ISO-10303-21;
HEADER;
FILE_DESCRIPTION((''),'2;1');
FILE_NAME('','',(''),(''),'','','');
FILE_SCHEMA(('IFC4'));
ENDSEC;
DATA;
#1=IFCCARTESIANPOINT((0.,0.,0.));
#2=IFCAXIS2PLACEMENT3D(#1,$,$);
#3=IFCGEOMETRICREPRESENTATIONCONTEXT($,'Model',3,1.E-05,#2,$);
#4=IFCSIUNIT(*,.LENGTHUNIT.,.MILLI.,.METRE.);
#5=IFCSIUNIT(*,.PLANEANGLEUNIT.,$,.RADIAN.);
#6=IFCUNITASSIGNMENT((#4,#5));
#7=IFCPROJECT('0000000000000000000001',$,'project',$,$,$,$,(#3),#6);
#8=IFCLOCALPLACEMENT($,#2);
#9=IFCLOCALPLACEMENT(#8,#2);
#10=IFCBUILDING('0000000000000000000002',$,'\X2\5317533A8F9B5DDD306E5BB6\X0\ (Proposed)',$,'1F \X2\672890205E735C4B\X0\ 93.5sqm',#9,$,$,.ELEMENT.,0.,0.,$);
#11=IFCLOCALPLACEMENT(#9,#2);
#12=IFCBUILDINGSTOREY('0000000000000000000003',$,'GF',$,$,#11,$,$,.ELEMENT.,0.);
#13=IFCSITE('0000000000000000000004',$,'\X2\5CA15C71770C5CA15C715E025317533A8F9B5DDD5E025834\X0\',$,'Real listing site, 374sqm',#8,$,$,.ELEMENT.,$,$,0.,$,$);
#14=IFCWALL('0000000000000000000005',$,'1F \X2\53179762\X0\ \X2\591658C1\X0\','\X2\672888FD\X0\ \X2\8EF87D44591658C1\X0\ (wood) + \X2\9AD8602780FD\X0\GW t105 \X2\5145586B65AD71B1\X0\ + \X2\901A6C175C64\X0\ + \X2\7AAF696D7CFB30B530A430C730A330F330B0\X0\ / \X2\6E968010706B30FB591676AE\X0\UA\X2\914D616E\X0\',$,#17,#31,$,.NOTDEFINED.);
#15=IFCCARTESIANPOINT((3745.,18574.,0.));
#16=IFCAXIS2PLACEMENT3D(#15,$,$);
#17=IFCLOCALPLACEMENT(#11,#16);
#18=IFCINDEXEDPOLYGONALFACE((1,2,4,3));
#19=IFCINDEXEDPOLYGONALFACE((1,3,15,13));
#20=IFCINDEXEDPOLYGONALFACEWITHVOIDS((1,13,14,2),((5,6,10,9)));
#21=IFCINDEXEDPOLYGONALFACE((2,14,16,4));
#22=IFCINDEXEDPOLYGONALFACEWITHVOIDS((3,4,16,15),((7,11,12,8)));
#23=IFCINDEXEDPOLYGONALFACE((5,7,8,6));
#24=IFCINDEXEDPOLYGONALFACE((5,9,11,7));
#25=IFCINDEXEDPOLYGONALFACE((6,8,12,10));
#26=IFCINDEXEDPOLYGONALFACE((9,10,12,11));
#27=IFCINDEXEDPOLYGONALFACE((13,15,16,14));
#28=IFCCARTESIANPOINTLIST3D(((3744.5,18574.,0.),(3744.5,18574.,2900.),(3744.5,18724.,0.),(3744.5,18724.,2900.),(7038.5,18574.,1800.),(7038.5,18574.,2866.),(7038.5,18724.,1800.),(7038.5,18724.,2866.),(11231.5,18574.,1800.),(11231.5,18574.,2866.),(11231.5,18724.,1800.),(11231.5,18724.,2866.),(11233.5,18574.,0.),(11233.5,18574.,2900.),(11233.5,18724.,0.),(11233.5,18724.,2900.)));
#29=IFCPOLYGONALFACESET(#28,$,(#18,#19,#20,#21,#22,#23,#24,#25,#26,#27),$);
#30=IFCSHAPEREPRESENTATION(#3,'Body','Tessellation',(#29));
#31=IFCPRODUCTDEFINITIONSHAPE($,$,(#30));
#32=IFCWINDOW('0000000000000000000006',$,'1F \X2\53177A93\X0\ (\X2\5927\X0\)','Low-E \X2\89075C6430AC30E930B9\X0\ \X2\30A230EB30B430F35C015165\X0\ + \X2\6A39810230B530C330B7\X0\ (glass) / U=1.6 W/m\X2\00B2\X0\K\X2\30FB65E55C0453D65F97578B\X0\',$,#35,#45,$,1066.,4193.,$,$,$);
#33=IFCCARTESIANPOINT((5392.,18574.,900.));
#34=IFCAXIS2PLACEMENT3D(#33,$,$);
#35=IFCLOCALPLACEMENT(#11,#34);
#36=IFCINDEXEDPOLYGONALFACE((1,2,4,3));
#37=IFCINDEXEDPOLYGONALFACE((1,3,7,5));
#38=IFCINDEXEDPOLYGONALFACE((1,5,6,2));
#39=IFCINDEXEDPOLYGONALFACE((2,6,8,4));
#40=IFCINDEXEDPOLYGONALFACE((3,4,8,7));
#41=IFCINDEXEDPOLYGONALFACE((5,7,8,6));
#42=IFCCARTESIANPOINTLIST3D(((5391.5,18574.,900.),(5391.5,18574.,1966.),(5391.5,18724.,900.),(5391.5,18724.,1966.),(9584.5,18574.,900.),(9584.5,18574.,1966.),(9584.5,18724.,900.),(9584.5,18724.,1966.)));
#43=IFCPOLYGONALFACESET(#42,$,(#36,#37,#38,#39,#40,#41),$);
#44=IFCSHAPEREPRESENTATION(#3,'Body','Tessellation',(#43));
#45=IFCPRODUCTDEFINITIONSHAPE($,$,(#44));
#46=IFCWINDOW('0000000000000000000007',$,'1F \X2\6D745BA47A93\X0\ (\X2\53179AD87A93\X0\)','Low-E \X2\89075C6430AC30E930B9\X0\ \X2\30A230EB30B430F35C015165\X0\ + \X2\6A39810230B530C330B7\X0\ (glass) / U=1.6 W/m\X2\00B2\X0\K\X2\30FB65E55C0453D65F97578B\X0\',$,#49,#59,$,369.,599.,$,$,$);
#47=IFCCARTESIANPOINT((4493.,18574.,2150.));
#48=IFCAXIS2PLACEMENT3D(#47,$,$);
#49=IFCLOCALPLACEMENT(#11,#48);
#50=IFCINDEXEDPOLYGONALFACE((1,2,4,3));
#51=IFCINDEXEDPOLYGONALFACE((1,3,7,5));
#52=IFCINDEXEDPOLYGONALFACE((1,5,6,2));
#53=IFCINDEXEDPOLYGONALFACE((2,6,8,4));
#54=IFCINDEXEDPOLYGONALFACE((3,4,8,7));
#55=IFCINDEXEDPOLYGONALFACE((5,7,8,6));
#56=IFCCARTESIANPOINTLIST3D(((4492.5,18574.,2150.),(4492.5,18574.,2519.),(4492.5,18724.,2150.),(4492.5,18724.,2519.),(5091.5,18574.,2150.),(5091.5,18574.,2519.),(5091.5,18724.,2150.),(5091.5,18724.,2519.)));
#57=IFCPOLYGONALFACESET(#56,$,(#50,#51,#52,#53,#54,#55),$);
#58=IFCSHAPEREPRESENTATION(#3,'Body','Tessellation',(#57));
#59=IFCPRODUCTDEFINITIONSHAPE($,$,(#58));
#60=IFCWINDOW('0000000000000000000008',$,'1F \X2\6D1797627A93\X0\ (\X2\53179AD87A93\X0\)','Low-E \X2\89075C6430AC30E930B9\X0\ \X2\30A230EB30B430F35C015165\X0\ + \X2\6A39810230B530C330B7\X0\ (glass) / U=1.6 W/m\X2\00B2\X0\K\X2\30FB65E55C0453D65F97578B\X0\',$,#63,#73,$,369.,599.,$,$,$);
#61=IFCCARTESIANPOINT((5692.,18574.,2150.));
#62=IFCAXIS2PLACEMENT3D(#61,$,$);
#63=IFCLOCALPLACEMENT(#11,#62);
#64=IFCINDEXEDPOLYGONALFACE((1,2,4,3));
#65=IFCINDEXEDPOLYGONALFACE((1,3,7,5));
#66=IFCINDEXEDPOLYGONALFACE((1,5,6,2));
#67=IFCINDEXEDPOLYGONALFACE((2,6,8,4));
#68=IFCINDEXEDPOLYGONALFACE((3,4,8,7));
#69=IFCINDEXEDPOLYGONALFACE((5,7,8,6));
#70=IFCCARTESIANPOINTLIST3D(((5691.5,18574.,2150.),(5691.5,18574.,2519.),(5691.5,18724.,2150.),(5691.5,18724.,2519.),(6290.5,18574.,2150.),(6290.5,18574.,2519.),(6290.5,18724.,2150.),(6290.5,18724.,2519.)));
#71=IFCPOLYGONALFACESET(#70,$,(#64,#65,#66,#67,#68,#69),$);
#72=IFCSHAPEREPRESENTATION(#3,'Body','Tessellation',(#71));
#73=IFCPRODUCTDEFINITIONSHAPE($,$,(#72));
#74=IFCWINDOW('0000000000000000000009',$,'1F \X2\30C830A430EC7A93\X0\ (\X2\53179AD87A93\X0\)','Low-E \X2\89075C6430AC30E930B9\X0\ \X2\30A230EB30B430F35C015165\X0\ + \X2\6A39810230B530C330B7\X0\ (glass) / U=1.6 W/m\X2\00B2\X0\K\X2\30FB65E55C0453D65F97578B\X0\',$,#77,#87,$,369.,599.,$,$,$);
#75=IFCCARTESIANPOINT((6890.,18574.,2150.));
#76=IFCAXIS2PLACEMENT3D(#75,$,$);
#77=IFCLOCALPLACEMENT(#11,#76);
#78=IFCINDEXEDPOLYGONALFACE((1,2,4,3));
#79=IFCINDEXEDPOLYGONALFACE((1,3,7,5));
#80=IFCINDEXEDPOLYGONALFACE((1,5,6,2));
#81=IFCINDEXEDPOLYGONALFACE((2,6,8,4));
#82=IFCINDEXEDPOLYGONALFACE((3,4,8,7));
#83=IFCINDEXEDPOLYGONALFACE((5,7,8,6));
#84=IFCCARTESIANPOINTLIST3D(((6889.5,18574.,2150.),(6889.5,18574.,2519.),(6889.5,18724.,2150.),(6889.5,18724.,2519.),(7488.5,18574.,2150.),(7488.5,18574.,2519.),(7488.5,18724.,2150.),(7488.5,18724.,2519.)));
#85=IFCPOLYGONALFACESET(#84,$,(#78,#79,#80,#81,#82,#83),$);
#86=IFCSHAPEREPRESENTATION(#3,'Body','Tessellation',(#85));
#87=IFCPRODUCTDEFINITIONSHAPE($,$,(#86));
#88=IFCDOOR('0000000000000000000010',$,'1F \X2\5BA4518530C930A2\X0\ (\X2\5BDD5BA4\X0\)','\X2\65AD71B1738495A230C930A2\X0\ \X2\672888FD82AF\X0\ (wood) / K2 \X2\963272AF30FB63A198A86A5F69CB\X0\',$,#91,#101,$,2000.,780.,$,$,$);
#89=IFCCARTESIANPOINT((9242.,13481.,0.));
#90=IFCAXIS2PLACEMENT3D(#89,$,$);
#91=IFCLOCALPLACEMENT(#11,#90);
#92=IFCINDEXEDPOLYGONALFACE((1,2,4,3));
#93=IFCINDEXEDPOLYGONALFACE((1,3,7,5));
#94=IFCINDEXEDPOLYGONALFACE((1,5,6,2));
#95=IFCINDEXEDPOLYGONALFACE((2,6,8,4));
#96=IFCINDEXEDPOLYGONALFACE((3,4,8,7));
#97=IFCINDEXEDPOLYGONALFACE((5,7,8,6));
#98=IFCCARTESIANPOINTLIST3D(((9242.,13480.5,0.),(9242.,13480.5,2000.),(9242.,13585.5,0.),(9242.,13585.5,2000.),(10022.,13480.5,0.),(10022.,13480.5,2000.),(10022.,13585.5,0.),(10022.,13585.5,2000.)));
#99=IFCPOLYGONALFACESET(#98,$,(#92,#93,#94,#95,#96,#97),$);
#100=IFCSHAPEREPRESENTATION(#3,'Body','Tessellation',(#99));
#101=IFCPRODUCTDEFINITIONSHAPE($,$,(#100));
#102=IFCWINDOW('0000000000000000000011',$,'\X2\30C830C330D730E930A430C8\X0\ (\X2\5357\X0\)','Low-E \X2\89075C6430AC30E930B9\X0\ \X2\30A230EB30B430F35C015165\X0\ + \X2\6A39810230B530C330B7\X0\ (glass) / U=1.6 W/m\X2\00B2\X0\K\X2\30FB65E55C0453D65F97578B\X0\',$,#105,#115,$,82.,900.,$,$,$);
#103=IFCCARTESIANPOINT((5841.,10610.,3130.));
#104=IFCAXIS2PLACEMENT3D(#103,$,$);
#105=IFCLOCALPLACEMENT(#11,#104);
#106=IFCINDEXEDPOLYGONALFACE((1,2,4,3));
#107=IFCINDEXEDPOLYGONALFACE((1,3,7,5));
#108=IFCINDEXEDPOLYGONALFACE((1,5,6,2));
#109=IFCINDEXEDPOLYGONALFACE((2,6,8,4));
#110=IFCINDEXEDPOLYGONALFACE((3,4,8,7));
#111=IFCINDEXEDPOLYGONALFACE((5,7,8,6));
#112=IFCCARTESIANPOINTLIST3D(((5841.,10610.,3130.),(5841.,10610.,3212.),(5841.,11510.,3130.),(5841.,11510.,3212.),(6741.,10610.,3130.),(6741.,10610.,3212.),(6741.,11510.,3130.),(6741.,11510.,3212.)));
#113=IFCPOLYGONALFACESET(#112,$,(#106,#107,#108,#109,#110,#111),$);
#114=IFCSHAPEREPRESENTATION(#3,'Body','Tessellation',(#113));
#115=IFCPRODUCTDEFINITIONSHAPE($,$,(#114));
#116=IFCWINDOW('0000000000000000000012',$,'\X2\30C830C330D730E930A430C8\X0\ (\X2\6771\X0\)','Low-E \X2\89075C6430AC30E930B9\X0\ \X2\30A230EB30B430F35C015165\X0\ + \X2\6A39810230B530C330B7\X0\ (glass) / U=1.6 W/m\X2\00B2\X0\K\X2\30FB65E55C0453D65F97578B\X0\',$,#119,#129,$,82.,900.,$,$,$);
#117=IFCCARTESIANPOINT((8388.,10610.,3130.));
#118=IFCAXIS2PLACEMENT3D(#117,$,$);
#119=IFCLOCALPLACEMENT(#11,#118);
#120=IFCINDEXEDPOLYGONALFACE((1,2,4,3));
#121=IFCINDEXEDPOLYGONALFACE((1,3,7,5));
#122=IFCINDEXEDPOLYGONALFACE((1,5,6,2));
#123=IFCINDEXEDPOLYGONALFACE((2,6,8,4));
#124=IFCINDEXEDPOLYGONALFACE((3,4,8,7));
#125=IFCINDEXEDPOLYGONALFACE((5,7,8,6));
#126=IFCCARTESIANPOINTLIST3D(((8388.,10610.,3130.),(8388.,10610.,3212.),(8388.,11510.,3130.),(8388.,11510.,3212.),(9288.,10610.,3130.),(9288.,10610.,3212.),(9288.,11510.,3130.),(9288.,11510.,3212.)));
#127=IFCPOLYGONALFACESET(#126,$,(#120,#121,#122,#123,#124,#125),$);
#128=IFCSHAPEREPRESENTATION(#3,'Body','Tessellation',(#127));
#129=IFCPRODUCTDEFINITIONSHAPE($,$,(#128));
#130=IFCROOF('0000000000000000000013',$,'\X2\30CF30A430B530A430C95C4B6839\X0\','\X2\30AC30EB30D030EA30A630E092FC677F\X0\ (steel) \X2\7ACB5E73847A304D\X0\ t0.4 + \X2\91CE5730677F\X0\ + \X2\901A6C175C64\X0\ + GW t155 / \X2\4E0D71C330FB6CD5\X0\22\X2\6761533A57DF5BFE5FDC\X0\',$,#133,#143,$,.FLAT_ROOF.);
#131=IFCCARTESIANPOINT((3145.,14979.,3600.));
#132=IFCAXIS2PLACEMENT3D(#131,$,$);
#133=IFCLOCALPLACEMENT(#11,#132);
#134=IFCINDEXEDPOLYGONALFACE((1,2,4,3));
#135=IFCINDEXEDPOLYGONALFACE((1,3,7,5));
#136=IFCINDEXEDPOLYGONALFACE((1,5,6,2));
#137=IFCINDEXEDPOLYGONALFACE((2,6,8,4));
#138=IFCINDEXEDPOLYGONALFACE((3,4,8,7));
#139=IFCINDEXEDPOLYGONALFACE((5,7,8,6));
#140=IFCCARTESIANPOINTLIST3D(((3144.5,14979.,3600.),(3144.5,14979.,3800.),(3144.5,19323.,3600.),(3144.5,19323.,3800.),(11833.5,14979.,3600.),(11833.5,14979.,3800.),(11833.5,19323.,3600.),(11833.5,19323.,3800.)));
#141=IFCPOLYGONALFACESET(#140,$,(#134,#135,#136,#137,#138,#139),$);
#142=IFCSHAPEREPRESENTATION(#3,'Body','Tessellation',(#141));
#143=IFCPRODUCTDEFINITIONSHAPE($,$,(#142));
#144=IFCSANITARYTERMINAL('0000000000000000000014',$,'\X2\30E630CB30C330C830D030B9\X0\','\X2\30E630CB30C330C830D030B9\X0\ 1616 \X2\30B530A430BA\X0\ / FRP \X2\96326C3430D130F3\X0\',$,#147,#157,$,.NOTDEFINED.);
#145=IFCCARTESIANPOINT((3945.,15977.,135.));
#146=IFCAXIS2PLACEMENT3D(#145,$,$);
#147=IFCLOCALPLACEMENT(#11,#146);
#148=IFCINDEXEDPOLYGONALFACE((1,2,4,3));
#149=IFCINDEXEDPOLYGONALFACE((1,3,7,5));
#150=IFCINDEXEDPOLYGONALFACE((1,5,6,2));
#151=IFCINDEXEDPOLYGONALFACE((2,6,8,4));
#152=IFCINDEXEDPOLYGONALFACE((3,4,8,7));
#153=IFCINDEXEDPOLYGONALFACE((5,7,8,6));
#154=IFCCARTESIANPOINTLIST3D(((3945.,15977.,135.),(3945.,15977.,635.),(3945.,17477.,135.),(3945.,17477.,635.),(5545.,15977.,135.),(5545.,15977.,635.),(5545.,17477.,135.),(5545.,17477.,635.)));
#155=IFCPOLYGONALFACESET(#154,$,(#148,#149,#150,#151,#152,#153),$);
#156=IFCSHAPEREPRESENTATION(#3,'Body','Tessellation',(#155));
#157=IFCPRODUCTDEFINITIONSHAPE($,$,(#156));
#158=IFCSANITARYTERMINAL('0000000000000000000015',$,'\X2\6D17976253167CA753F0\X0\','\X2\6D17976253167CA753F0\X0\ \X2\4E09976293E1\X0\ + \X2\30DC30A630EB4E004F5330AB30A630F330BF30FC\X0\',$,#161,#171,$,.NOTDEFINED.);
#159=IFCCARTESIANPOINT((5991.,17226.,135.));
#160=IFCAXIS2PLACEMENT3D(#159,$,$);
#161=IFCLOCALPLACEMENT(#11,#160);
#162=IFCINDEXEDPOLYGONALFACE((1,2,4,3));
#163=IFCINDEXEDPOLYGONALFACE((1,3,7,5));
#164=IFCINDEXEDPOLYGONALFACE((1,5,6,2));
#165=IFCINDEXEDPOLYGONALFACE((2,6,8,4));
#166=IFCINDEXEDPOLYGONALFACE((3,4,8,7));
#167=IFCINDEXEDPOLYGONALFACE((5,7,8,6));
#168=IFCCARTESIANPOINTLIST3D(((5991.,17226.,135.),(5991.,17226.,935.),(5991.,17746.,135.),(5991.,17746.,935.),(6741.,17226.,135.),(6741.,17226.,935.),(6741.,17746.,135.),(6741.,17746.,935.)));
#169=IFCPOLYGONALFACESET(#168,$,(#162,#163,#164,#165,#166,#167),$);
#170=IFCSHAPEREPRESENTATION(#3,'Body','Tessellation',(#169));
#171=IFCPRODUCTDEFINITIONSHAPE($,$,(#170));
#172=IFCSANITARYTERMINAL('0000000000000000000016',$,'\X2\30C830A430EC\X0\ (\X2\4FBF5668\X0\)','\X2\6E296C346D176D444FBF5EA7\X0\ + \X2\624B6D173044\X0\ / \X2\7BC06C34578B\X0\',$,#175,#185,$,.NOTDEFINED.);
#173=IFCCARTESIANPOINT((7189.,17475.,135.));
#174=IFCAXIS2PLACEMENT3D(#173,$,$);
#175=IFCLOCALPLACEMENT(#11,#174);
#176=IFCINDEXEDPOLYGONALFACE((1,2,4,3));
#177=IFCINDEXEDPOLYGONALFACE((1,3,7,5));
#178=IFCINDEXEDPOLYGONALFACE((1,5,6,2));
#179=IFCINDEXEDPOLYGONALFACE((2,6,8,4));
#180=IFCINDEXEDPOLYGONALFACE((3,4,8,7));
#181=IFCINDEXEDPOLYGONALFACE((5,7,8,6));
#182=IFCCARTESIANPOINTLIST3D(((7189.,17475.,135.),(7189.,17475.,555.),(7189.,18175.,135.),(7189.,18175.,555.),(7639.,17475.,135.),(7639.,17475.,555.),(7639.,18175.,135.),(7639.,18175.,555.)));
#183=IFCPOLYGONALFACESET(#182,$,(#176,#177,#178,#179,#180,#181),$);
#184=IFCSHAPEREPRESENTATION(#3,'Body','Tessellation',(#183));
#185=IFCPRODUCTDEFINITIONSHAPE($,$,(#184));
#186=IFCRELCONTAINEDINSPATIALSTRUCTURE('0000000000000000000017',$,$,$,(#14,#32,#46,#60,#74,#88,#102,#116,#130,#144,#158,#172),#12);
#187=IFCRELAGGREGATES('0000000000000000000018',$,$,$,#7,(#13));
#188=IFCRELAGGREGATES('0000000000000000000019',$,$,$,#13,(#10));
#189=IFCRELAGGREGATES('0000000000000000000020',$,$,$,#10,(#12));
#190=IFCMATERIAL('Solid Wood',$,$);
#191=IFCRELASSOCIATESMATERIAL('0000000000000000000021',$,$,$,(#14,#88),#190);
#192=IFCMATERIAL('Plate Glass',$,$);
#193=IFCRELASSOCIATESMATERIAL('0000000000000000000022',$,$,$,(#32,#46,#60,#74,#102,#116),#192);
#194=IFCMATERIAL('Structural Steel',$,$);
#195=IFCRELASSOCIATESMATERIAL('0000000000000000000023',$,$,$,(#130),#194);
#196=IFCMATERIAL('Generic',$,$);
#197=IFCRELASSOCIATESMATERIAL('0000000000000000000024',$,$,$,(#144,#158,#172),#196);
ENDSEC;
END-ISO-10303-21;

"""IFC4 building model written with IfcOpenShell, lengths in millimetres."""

from ifc_helpers import new_model, si_unit, frame, frame_2d, origin, place, context, project, spatial, rectangle, extrude, material, element, fill, save


model = new_model("IFC4")

# Units and contexts
model_context = context("Model", 3, precision=1e-05, world=origin())
ifc_project = project(units=[si_unit("LENGTHUNIT", "METRE", prefix="MILLI"), si_unit("PLANEANGLEUNIT", "RADIAN")], contexts=[model_context])

# Site, building, storey
site_placement = place(None, origin())
site = spatial("IfcSite", under=ifc_project, at=site_placement, Name="岡山県岡山市北区辛川市場", ObjectType="Real listing site, 374sqm", CompositionType="ELEMENT", RefElevation=0.0)
building_placement = place(site_placement, origin())
building = spatial("IfcBuilding", under=site, at=building_placement, Name="北区辛川の家 (Proposed)", ObjectType="1F 木造平屋 93.5sqm", CompositionType="ELEMENT", ElevationOfRefHeight=0.0, ElevationOfTerrain=0.0)
storey_placement = place(building_placement, origin())
storey = spatial("IfcBuildingStorey", under=building, at=storey_placement, Name="GF", CompositionType="ELEMENT", Elevation=0.0)

# Shared definitions
ifc_material_1 = material(Name="Solid Wood")

# Wall, openings, windows
wall_1_placement = place(storey_placement, frame((3745.0, 18574.0, 0.0)))
wall_1 = element("IfcWall", 1, at=wall_1_placement, inside=storey, material=ifc_material_1, Name="1F 北面 外壁", Description="木製 軸組外壁 (wood) + 高性能GW t105 充填断熱 + 通気層 + 窯業系サイディング / 準耐火・外皮UA配慮", PredefinedType="NOTDEFINED", context=model_context, shape_type="SweptSolid", body=[
    extrude(rectangle(XDim=7489.0, YDim=150.0, at=frame_2d((3744.0, 75.0))), frame((3745.0, 18574.0, 0.0)), (0.0, 0.0, 1.0), 2900.0),
])
opening_1_placement = place(storey_placement, frame((5392.0, 18574.0, 900.0)))
opening_1 = element("IfcOpeningElement", 2, at=opening_1_placement, cuts=wall_1, PredefinedType="NOTDEFINED", context=model_context, shape_type="SweptSolid", body=[
    extrude(rectangle(XDim=4193.0, YDim=150.0, at=frame_2d((2096.0, 75.0))), frame((5392.0, 18574.0, 900.0)), (0.0, 0.0, 1.0), 1066.0),
])
opening_2_placement = place(storey_placement, frame((4493.0, 18574.0, 2150.0)))
opening_2 = element("IfcOpeningElement", 3, at=opening_2_placement, cuts=wall_1, PredefinedType="NOTDEFINED", context=model_context, shape_type="SweptSolid", body=[
    extrude(rectangle(XDim=599.0, YDim=150.0, at=frame_2d((299.0, 75.0))), frame((4493.0, 18574.0, 2150.0)), (0.0, 0.0, 1.0), 369.0),
])
opening_3_placement = place(storey_placement, frame((5692.0, 18574.0, 2150.0)))
opening_3 = element("IfcOpeningElement", 4, at=opening_3_placement, cuts=wall_1, PredefinedType="NOTDEFINED", context=model_context, shape_type="SweptSolid", body=[
    extrude(rectangle(XDim=599.0, YDim=150.0, at=frame_2d((299.0, 75.0))), frame((5692.0, 18574.0, 2150.0)), (0.0, 0.0, 1.0), 369.0),
])
opening_4_placement = place(storey_placement, frame((6890.0, 18574.0, 2150.0)))
opening_4 = element("IfcOpeningElement", 5, at=opening_4_placement, cuts=wall_1, PredefinedType="NOTDEFINED", context=model_context, shape_type="SweptSolid", body=[
    extrude(rectangle(XDim=599.0, YDim=150.0, at=frame_2d((299.0, 75.0))), frame((6890.0, 18574.0, 2150.0)), (0.0, 0.0, 1.0), 369.0),
])
ifc_material_2 = material(Name="Plate Glass")
window_1_placement = place(storey_placement, frame((5392.0, 18574.0, 900.0)))
window_1 = element("IfcWindow", 6, at=window_1_placement, inside=storey, material=ifc_material_2, Name="1F 北窓 (大)", Description="Low-E 複層ガラス アルゴン封入 + 樹脂サッシ (glass) / U=1.6 W/m²K・日射取得型", OverallHeight=1066.0, OverallWidth=4193.0, context=model_context, shape_type="SweptSolid", body=[
    extrude(rectangle(XDim=4193.0, YDim=150.0, at=frame_2d((2096.0, 75.0))), frame((5392.0, 18574.0, 900.0)), (0.0, 0.0, 1.0), 1066.0),
])
fill(opening_1, window_1)
window_2_placement = place(storey_placement, frame((4493.0, 18574.0, 2150.0)))
window_2 = element("IfcWindow", 7, at=window_2_placement, inside=storey, material=ifc_material_2, Name="1F 浴室窓 (北高窓)", Description="Low-E 複層ガラス アルゴン封入 + 樹脂サッシ (glass) / U=1.6 W/m²K・日射取得型", OverallHeight=369.0, OverallWidth=599.0, context=model_context, shape_type="SweptSolid", body=[
    extrude(rectangle(XDim=599.0, YDim=150.0, at=frame_2d((299.0, 75.0))), frame((4493.0, 18574.0, 2150.0)), (0.0, 0.0, 1.0), 369.0),
])
fill(opening_2, window_2)
window_3_placement = place(storey_placement, frame((5692.0, 18574.0, 2150.0)))
window_3 = element("IfcWindow", 8, at=window_3_placement, inside=storey, material=ifc_material_2, Name="1F 洗面窓 (北高窓)", Description="Low-E 複層ガラス アルゴン封入 + 樹脂サッシ (glass) / U=1.6 W/m²K・日射取得型", OverallHeight=369.0, OverallWidth=599.0, context=model_context, shape_type="SweptSolid", body=[
    extrude(rectangle(XDim=599.0, YDim=150.0, at=frame_2d((299.0, 75.0))), frame((5692.0, 18574.0, 2150.0)), (0.0, 0.0, 1.0), 369.0),
])
fill(opening_3, window_3)
window_4_placement = place(storey_placement, frame((6890.0, 18574.0, 2150.0)))
window_4 = element("IfcWindow", 9, at=window_4_placement, inside=storey, material=ifc_material_2, Name="1F トイレ窓 (北高窓)", Description="Low-E 複層ガラス アルゴン封入 + 樹脂サッシ (glass) / U=1.6 W/m²K・日射取得型", OverallHeight=369.0, OverallWidth=599.0, context=model_context, shape_type="SweptSolid", body=[
    extrude(rectangle(XDim=599.0, YDim=150.0, at=frame_2d((299.0, 75.0))), frame((6890.0, 18574.0, 2150.0)), (0.0, 0.0, 1.0), 369.0),
])
fill(opening_4, window_4)

# Door
door_1_placement = place(storey_placement, frame((9242.0, 13481.0, 0.0)))
element("IfcDoor", 10, at=door_1_placement, inside=storey, material=ifc_material_1, Name="1F 室内ドア (寝室)", Description="断熱玄関ドア 木製芯 (wood) / K2 防犯・採風機構", OverallHeight=2000.0, OverallWidth=780.0, context=model_context, shape_type="SweptSolid", body=[
    extrude(rectangle(XDim=780.0, YDim=105.0, at=frame_2d((390.0, 52.0))), frame((9242.0, 13481.0, 0.0)), (0.0, 0.0, 1.0), 2000.0),
])

# Windows
window_5_placement = place(storey_placement, frame((5841.0, 10610.0, 3130.0)))
element("IfcWindow", 11, at=window_5_placement, inside=storey, material=ifc_material_2, Name="トップライト (南)", Description="Low-E 複層ガラス アルゴン封入 + 樹脂サッシ (glass) / U=1.6 W/m²K・日射取得型", OverallHeight=82.0, OverallWidth=900.0, context=model_context, shape_type="SweptSolid", body=[
    extrude(rectangle(XDim=900.0, YDim=900.0, at=frame_2d((450.0, 450.0))), frame((5841.0, 10610.0, 3130.0)), (0.0, 0.0, 1.0), 82.0),
])
window_6_placement = place(storey_placement, frame((8388.0, 10610.0, 3130.0)))
element("IfcWindow", 12, at=window_6_placement, inside=storey, material=ifc_material_2, Name="トップライト (東)", Description="Low-E 複層ガラス アルゴン封入 + 樹脂サッシ (glass) / U=1.6 W/m²K・日射取得型", OverallHeight=82.0, OverallWidth=900.0, context=model_context, shape_type="SweptSolid", body=[
    extrude(rectangle(XDim=900.0, YDim=900.0, at=frame_2d((450.0, 450.0))), frame((8388.0, 10610.0, 3130.0)), (0.0, 0.0, 1.0), 82.0),
])

# Roof
ifc_material_3 = material(Name="Structural Steel")
roof_placement = place(storey_placement, frame((3145.0, 14979.0, 3600.0)))
element("IfcRoof", 13, at=roof_placement, inside=storey, material=ifc_material_3, Name="ハイサイド屋根", Description="ガルバリウム鋼板 (steel) 立平葺き t0.4 + 野地板 + 通気層 + GW t155 / 不燃・法22条区域対応", PredefinedType="FLAT_ROOF", context=model_context, shape_type="SweptSolid", body=[
    extrude(rectangle(XDim=8689.0, YDim=4344.0, at=frame_2d((4344.0, 2172.0))), frame((3145.0, 14979.0, 3600.0)), (0.0, 0.0, 1.0), 200.0),
])

# Sanitary terminals
ifc_material_4 = material(Name="Generic")
sanitary_terminal_1_placement = place(storey_placement, frame((3945.0, 15977.0, 135.0)))
element("IfcSanitaryTerminal", 14, at=sanitary_terminal_1_placement, inside=storey, material=ifc_material_4, Name="ユニットバス", Description="ユニットバス 1616 サイズ / FRP 防水パン", PredefinedType="NOTDEFINED", context=model_context, shape_type="SweptSolid", body=[
    extrude(rectangle(XDim=1600.0, YDim=1500.0, at=frame_2d((800.0, 750.0))), frame((3945.0, 15977.0, 135.0)), (0.0, 0.0, 1.0), 500.0),
])
sanitary_terminal_2_placement = place(storey_placement, frame((5991.0, 17226.0, 135.0)))
element("IfcSanitaryTerminal", 15, at=sanitary_terminal_2_placement, inside=storey, material=ifc_material_4, Name="洗面化粧台", Description="洗面化粧台 三面鏡 + ボウル一体カウンター", PredefinedType="NOTDEFINED", context=model_context, shape_type="SweptSolid", body=[
    extrude(rectangle(XDim=750.0, YDim=520.0, at=frame_2d((375.0, 260.0))), frame((5991.0, 17226.0, 135.0)), (0.0, 0.0, 1.0), 800.0),
])
sanitary_terminal_3_placement = place(storey_placement, frame((7189.0, 17475.0, 135.0)))
element("IfcSanitaryTerminal", 16, at=sanitary_terminal_3_placement, inside=storey, material=ifc_material_4, Name="トイレ (便器)", Description="温水洗浄便座 + 手洗い / 節水型", PredefinedType="NOTDEFINED", context=model_context, shape_type="SweptSolid", body=[
    extrude(rectangle(XDim=450.0, YDim=700.0, at=frame_2d((225.0, 350.0))), frame((7189.0, 17475.0, 135.0)), (0.0, 0.0, 1.0), 420.0),
])

save(model, "model.ifc")
